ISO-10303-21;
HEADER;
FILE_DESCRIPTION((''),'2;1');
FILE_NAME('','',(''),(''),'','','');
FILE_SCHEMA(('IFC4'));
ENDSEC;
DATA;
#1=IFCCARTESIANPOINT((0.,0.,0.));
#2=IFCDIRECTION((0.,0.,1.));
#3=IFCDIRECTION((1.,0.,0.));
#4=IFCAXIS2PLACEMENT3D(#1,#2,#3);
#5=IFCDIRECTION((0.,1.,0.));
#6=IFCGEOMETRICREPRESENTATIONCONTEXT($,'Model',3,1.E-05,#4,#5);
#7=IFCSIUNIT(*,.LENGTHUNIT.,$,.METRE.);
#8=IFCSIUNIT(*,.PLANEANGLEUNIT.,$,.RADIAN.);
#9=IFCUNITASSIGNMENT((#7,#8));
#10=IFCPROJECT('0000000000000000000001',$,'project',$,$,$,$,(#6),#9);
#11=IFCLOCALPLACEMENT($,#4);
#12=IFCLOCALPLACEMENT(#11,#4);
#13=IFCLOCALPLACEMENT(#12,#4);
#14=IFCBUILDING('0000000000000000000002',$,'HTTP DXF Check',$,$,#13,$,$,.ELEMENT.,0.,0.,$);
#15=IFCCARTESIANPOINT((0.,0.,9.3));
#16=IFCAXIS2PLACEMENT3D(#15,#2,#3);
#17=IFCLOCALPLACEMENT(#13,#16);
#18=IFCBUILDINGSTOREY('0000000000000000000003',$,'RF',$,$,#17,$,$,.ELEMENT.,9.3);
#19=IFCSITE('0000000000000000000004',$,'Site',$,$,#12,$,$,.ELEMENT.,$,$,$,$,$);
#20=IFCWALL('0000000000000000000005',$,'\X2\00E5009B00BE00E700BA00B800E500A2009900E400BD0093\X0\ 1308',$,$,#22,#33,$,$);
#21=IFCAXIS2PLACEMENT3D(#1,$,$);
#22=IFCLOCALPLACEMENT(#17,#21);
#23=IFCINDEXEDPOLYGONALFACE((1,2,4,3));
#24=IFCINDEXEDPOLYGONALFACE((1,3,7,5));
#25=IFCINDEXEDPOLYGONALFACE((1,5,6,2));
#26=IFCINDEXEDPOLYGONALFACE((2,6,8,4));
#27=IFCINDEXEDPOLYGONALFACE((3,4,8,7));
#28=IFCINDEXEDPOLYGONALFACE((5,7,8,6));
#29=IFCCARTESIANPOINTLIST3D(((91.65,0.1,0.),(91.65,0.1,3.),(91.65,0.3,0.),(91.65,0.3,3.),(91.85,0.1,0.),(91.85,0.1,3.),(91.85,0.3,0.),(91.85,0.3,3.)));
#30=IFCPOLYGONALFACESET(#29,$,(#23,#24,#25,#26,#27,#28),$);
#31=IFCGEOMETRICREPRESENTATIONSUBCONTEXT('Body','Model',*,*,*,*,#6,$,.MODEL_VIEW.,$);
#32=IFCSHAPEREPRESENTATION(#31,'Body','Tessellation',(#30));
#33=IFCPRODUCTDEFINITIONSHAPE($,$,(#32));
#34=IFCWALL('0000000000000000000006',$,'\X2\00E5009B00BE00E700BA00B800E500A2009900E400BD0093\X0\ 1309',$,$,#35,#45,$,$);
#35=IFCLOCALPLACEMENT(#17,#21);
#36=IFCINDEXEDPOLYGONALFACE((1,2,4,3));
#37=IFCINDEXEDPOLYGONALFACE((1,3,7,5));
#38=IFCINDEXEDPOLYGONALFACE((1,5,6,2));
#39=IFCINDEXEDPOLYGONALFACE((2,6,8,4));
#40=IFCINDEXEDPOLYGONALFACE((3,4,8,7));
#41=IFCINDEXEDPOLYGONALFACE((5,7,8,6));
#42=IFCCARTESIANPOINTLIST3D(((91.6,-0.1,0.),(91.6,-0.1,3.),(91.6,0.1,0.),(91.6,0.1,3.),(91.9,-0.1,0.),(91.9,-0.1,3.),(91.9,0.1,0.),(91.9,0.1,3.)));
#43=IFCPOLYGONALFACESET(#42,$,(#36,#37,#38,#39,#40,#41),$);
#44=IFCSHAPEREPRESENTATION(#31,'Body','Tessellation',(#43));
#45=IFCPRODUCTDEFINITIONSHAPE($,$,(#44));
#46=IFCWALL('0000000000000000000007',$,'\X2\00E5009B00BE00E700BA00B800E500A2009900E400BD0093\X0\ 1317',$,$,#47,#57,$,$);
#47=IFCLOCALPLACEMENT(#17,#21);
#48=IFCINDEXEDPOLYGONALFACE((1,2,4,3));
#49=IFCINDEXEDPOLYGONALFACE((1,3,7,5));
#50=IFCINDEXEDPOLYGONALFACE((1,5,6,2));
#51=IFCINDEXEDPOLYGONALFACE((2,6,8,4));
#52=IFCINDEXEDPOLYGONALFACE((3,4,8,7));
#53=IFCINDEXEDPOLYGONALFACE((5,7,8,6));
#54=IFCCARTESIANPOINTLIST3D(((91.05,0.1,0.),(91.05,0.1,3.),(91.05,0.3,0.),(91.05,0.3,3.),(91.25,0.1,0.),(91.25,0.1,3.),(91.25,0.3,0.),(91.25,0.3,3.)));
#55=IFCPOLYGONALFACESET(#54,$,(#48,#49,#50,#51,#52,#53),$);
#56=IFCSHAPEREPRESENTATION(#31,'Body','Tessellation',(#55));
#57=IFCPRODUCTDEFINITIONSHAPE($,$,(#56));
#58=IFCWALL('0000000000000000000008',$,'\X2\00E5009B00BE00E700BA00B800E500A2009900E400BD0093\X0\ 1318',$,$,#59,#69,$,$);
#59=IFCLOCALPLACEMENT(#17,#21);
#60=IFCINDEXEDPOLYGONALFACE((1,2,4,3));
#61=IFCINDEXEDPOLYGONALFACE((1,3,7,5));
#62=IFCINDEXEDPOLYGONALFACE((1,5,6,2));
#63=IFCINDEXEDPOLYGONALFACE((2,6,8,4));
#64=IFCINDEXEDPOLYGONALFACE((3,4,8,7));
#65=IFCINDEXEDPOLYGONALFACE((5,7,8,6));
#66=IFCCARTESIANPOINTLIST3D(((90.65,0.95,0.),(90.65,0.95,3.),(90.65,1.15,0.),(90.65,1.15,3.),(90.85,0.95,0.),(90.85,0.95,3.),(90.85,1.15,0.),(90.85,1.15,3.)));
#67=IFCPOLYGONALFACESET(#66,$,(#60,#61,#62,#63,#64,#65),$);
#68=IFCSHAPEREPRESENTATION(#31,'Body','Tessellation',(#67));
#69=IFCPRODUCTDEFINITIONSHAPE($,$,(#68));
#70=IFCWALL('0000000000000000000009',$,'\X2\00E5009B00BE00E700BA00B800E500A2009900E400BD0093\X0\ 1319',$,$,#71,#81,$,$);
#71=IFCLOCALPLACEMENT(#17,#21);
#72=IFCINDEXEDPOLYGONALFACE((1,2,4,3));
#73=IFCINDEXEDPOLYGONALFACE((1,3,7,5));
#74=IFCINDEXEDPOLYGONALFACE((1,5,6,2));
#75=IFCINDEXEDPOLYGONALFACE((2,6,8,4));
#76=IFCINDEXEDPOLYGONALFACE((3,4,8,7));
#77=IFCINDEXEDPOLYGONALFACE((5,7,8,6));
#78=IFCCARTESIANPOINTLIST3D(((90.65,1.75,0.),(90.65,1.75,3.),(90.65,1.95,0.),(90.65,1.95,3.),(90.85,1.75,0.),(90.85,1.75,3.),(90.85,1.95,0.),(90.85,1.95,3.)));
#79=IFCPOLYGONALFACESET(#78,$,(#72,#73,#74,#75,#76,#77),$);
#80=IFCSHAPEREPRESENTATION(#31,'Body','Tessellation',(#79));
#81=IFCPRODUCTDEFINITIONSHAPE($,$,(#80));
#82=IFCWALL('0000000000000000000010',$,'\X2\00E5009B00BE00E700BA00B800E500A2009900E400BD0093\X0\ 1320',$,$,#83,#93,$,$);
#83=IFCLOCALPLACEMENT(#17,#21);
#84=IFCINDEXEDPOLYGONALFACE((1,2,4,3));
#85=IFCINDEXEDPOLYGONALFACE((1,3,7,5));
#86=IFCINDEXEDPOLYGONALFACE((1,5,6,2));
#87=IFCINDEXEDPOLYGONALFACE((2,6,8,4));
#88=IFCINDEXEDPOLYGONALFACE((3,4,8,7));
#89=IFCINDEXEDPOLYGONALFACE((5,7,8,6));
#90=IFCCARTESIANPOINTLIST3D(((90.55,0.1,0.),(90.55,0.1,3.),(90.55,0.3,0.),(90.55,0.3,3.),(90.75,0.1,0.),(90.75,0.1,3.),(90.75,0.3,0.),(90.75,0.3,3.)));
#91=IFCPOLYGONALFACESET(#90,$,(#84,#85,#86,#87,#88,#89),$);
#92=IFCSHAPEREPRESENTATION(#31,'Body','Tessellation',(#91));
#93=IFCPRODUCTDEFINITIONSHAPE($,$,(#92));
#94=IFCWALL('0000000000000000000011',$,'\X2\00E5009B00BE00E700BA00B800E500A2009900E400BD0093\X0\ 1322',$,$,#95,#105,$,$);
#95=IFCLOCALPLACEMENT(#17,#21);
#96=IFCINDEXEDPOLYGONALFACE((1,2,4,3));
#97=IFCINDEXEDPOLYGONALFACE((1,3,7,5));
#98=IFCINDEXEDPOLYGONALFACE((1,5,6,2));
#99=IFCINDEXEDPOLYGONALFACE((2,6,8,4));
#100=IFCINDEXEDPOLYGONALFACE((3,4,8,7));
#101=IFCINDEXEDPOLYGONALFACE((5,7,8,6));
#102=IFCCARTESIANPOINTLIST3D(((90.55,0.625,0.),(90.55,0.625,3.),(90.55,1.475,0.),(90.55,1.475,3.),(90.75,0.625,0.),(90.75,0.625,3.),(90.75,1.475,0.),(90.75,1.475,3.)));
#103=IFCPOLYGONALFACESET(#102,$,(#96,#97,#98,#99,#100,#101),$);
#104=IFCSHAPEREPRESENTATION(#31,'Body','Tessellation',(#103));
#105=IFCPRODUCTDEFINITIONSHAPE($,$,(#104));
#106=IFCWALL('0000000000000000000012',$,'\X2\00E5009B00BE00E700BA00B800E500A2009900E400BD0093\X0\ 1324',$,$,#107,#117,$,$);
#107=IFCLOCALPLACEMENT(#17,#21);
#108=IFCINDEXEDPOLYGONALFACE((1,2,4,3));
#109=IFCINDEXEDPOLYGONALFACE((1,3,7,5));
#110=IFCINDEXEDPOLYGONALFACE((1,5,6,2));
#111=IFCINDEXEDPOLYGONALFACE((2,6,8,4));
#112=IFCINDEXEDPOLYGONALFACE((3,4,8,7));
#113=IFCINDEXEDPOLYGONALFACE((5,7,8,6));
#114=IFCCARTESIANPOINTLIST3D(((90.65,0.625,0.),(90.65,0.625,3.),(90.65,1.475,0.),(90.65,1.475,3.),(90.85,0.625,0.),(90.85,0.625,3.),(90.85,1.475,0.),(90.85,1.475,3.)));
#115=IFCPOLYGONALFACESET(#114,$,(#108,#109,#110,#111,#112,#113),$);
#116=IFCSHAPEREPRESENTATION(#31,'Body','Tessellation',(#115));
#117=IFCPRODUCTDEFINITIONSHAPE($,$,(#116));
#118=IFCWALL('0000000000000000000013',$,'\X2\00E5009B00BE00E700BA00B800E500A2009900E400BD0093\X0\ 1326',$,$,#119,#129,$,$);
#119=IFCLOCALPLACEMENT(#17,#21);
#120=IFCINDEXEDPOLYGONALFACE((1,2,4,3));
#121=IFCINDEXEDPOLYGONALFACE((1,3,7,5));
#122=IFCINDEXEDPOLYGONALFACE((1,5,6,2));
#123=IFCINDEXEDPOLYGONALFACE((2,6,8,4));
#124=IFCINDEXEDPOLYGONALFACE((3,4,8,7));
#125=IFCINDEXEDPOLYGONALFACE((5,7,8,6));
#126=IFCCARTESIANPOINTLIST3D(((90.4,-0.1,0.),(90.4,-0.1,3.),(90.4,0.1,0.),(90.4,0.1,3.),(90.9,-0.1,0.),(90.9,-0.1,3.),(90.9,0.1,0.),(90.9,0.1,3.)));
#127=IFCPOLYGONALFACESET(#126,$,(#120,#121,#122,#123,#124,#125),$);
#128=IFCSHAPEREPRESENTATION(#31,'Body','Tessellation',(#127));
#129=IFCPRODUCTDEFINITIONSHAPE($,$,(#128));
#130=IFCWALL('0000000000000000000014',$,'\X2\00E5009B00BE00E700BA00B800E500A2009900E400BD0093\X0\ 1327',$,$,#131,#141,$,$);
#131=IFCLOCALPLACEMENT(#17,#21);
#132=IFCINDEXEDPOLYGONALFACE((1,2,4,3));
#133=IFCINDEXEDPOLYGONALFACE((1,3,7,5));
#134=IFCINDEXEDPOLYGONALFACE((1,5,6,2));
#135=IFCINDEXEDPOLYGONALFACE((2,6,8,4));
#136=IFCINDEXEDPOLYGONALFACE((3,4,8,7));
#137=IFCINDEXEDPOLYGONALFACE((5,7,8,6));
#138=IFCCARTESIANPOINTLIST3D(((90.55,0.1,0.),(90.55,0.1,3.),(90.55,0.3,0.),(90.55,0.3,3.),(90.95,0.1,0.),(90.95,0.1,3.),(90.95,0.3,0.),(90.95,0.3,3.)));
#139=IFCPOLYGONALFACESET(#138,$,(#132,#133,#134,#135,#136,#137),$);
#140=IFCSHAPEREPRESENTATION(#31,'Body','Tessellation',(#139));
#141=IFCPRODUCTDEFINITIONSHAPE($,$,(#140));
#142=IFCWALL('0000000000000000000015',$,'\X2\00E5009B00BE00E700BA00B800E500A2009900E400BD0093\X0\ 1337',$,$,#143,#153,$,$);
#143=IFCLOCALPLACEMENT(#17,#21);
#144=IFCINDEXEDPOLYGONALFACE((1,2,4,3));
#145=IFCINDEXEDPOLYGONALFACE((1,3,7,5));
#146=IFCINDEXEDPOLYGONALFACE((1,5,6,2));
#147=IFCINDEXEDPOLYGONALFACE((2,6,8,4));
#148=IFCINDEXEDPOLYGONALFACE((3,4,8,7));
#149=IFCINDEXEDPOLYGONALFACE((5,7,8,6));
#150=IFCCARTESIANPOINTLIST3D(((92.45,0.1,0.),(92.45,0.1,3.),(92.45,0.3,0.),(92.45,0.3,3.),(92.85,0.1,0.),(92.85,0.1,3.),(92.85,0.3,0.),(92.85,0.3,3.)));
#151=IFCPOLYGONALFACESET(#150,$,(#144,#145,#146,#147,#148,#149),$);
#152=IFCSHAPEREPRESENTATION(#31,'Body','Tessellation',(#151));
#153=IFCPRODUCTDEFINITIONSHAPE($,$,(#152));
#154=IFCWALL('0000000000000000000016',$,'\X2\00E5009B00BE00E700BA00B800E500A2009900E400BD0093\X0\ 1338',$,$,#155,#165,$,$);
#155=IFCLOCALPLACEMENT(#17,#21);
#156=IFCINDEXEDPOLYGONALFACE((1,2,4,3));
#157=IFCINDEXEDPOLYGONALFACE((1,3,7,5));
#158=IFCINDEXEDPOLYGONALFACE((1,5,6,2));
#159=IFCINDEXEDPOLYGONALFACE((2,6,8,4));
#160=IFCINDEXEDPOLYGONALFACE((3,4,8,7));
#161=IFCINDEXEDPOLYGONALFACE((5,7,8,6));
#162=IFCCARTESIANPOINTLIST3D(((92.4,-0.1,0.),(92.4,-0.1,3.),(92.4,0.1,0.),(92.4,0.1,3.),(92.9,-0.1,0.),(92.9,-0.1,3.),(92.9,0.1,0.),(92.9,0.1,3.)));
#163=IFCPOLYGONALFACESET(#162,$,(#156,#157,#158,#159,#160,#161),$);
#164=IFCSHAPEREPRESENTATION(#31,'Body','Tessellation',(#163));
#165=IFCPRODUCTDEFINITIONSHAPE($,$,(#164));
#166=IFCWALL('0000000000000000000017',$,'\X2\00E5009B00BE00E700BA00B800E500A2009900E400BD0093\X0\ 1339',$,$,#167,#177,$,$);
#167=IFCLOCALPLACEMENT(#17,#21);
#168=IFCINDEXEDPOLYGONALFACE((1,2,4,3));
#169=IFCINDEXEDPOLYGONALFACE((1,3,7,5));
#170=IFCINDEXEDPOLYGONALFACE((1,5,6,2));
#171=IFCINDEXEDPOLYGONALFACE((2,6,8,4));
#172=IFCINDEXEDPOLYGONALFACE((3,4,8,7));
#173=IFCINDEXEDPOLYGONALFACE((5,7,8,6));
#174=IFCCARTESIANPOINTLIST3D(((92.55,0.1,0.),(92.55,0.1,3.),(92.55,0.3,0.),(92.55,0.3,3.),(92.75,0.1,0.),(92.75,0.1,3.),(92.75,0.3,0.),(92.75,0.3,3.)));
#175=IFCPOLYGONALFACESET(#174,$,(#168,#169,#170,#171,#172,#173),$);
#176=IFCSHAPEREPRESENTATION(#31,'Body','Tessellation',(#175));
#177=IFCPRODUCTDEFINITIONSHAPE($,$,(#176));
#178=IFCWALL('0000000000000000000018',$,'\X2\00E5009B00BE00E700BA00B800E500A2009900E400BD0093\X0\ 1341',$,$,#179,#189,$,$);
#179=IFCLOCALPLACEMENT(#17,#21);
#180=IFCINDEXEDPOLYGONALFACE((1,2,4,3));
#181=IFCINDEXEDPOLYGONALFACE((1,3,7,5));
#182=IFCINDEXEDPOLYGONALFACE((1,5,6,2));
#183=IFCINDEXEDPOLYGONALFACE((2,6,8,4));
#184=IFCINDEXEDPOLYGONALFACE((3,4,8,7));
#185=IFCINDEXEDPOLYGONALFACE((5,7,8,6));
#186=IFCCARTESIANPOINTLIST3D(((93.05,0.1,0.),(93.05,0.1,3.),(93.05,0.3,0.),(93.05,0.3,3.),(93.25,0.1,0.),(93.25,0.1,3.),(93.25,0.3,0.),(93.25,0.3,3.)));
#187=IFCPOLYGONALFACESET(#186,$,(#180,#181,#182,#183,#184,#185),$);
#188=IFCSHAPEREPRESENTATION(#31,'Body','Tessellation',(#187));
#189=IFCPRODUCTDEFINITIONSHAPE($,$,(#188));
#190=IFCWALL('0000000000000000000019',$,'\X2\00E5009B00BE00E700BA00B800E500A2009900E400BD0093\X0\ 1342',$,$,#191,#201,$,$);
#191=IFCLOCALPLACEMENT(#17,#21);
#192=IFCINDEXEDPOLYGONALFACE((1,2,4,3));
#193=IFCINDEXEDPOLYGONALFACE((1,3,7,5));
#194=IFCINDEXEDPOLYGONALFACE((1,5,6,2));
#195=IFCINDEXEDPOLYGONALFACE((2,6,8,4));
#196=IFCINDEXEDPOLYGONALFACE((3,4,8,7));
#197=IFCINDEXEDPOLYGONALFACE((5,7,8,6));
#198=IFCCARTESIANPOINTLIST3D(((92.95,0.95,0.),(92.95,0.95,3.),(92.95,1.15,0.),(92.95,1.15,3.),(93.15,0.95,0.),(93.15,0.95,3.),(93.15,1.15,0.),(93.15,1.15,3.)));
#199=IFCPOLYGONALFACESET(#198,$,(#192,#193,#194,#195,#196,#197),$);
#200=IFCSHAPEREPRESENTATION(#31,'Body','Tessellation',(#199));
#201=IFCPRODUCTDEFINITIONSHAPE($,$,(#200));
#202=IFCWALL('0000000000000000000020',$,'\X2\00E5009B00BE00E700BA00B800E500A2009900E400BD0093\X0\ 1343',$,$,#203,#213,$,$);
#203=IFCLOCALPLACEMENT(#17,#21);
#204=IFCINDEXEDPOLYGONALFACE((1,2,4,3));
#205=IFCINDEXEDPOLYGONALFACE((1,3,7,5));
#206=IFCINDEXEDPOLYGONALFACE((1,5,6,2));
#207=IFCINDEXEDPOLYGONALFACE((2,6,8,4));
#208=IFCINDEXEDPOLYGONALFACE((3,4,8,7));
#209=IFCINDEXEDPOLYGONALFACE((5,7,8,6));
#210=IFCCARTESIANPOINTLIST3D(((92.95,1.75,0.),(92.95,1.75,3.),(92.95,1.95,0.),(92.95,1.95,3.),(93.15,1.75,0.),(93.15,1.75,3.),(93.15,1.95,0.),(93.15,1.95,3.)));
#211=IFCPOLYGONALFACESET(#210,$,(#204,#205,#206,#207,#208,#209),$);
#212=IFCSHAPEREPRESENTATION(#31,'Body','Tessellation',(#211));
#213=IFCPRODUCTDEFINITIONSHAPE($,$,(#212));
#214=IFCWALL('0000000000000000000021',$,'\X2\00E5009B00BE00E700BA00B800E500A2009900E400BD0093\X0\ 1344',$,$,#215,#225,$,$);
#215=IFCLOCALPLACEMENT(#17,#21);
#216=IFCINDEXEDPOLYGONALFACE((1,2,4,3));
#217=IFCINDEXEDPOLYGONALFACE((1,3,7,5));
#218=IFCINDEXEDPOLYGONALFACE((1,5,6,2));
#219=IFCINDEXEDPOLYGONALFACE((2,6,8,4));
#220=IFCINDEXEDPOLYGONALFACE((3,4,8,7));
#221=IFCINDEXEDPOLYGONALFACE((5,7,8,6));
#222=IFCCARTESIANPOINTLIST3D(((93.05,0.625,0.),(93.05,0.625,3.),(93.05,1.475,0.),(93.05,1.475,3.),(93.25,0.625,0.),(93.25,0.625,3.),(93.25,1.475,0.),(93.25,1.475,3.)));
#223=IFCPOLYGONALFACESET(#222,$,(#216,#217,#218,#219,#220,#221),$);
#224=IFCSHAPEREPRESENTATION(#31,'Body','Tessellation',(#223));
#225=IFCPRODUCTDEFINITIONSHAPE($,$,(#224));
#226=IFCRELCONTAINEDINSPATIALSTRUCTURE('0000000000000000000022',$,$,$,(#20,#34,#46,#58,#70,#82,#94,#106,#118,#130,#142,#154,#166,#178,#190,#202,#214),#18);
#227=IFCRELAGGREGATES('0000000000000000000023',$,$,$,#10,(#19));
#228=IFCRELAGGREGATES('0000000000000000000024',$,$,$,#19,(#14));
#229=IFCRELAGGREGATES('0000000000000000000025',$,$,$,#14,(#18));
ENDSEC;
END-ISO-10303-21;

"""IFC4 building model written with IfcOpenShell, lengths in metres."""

from ifc_helpers import new_model, si_unit, direction, frame, frame_2d, origin_with_axes, place, context, subcontext, project, spatial, rectangle, extrude, element, save


model = new_model("IFC4")

# Units and contexts
model_context = context("Model", 3, precision=1e-05, world=origin_with_axes(), true_north=direction((0.0, 1.0, 0.0)))
body_context = subcontext(model_context, "Body", "Model", "MODEL_VIEW")
ifc_project = project(units=[si_unit("LENGTHUNIT", "METRE"), si_unit("PLANEANGLEUNIT", "RADIAN")], contexts=[model_context])

# Site, building, storey
placement = place(None, origin_with_axes())
site_placement = place(placement, origin_with_axes())
site = spatial("IfcSite", under=ifc_project, at=site_placement, Name="Site", CompositionType="ELEMENT")
building_placement = place(site_placement, origin_with_axes())
building = spatial("IfcBuilding", under=site, at=building_placement, Name="HTTP DXF Check", CompositionType="ELEMENT", ElevationOfRefHeight=0.0, ElevationOfTerrain=0.0)
storey_placement = place(building_placement, frame((0.0, 0.0, 9.3), z_axis=(0.0, 0.0, 1.0), x_axis=(1.0, 0.0, 0.0)))
storey = spatial("IfcBuildingStorey", under=building, at=storey_placement, Name="RF", CompositionType="ELEMENT", Elevation=9.3)

# Walls
wall_1_placement = place(storey_placement, frame((91.75, 0.2, 0.0), z_axis=(0.0, 0.0, 1.0), x_axis=(1.0, 0.0, 0.0)))
element("IfcWall", 1, at=wall_1_placement, inside=storey, Name="å\u009b¾çº¸å¢\u0099ä½\u0093 1308", context=body_context, shape_type="SweptSolid", body=[
    extrude(rectangle(XDim=0.2, YDim=0.2, at=frame_2d((0.0, 0.0), x_axis=(1.0, 0.0, 0.0))), frame((0.0, 0.0, 0.0), z_axis=(0.0, 0.0, 1.0)), (0.0, 0.0, 1.0), 3.0),
])
wall_2_placement = place(storey_placement, frame((91.75, 0.0, 0.0), z_axis=(0.0, 0.0, 1.0), x_axis=(1.0, 0.0, 0.0)))
element("IfcWall", 2, at=wall_2_placement, inside=storey, Name="å\u009b¾çº¸å¢\u0099ä½\u0093 1309", context=body_context, shape_type="SweptSolid", body=[
    extrude(rectangle(XDim=0.3, YDim=0.2, at=frame_2d((0.0, 0.0), x_axis=(1.0, 0.0, 0.0))), frame((0.0, 0.0, 0.0), z_axis=(0.0, 0.0, 1.0)), (0.0, 0.0, 1.0), 3.0),
])
for number, where, z_axis, x_axis, name in (
    (3, (91.15, 0.2, 0.0), (0.0, 0.0, 1.0), (0.0, -1.0, 0.0), "å\u009b¾çº¸å¢\u0099ä½\u0093 1317"),
    (4, (90.75, 1.05, 0.0), (0.0, 0.0, 1.0), (-1.0, 0.0, 0.0), "å\u009b¾çº¸å¢\u0099ä½\u0093 1318"),
    (5, (90.75, 1.85, 0.0), (0.0, 0.0, 1.0), (-1.0, 0.0, 0.0), "å\u009b¾çº¸å¢\u0099ä½\u0093 1319"),
    (6, (90.65, 0.2, 0.0), (0.0, 0.0, 1.0), (0.0, -1.0, 0.0), "å\u009b¾çº¸å¢\u0099ä½\u0093 1320"),
):
    element("IfcWall", number, at=place(storey_placement, frame(where, z_axis=z_axis, x_axis=x_axis)), inside=storey, Name=name, context=body_context, shape_type="SweptSolid", body=[
        extrude(rectangle(XDim=0.2, YDim=0.2, at=frame_2d((0.0, 0.0), x_axis=(1.0, 0.0, 0.0))), frame((0.0, 0.0, 0.0), z_axis=(0.0, 0.0, 1.0)), (0.0, 0.0, 1.0), 3.0),
    ])
for number, where, z_axis, x_axis, name in (
    (7, (90.65, 1.05, 0.0), (0.0, 0.0, 1.0), (0.0, -1.0, 0.0), "å\u009b¾çº¸å¢\u0099ä½\u0093 1322"),
    (8, (90.75, 1.05, 0.0), (0.0, 0.0, 1.0), (0.0, -1.0, 0.0), "å\u009b¾çº¸å¢\u0099ä½\u0093 1324"),
):
    element("IfcWall", number, at=place(storey_placement, frame(where, z_axis=z_axis, x_axis=x_axis)), inside=storey, Name=name, context=body_context, shape_type="SweptSolid", body=[
        extrude(rectangle(XDim=0.85, YDim=0.2, at=frame_2d((0.0, 0.0), x_axis=(1.0, 0.0, 0.0))), frame((0.0, 0.0, 0.0), z_axis=(0.0, 0.0, 1.0)), (0.0, 0.0, 1.0), 3.0),
    ])
wall_3_placement = place(storey_placement, frame((90.65, 0.0, 0.0), z_axis=(0.0, 0.0, 1.0), x_axis=(1.0, 0.0, 0.0)))
element("IfcWall", 9, at=wall_3_placement, inside=storey, Name="å\u009b¾çº¸å¢\u0099ä½\u0093 1326", context=body_context, shape_type="SweptSolid", body=[
    extrude(rectangle(XDim=0.5, YDim=0.2, at=frame_2d((0.0, 0.0), x_axis=(1.0, 0.0, 0.0))), frame((0.0, 0.0, 0.0), z_axis=(0.0, 0.0, 1.0)), (0.0, 0.0, 1.0), 3.0),
])
for number, where, z_axis, x_axis, name in (
    (10, (90.75, 0.2, 0.0), (0.0, 0.0, 1.0), (1.0, 0.0, 0.0), "å\u009b¾çº¸å¢\u0099ä½\u0093 1327"),
    (11, (92.65, 0.2, 0.0), (0.0, 0.0, 1.0), (1.0, 0.0, 0.0), "å\u009b¾çº¸å¢\u0099ä½\u0093 1337"),
):
    element("IfcWall", number, at=place(storey_placement, frame(where, z_axis=z_axis, x_axis=x_axis)), inside=storey, Name=name, context=body_context, shape_type="SweptSolid", body=[
        extrude(rectangle(XDim=0.4, YDim=0.2, at=frame_2d((0.0, 0.0), x_axis=(1.0, 0.0, 0.0))), frame((0.0, 0.0, 0.0), z_axis=(0.0, 0.0, 1.0)), (0.0, 0.0, 1.0), 3.0),
    ])
wall_4_placement = place(storey_placement, frame((92.65, 0.0, 0.0), z_axis=(0.0, 0.0, 1.0), x_axis=(1.0, 0.0, 0.0)))
element("IfcWall", 12, at=wall_4_placement, inside=storey, Name="å\u009b¾çº¸å¢\u0099ä½\u0093 1338", context=body_context, shape_type="SweptSolid", body=[
    extrude(rectangle(XDim=0.5, YDim=0.2, at=frame_2d((0.0, 0.0), x_axis=(1.0, 0.0, 0.0))), frame((0.0, 0.0, 0.0), z_axis=(0.0, 0.0, 1.0)), (0.0, 0.0, 1.0), 3.0),
])
for number, where, z_axis, x_axis, name in (
    (13, (92.65, 0.2, 0.0), (0.0, 0.0, 1.0), (0.0, -1.0, 0.0), "å\u009b¾çº¸å¢\u0099ä½\u0093 1339"),
    (14, (93.15, 0.2, 0.0), (0.0, 0.0, 1.0), (0.0, -1.0, 0.0), "å\u009b¾çº¸å¢\u0099ä½\u0093 1341"),
    (15, (93.05, 1.05, 0.0), (0.0, 0.0, 1.0), (1.0, 0.0, 0.0), "å\u009b¾çº¸å¢\u0099ä½\u0093 1342"),
    (16, (93.05, 1.85, 0.0), (0.0, 0.0, 1.0), (1.0, 0.0, 0.0), "å\u009b¾çº¸å¢\u0099ä½\u0093 1343"),
):
    element("IfcWall", number, at=place(storey_placement, frame(where, z_axis=z_axis, x_axis=x_axis)), inside=storey, Name=name, context=body_context, shape_type="SweptSolid", body=[
        extrude(rectangle(XDim=0.2, YDim=0.2, at=frame_2d((0.0, 0.0), x_axis=(1.0, 0.0, 0.0))), frame((0.0, 0.0, 0.0), z_axis=(0.0, 0.0, 1.0)), (0.0, 0.0, 1.0), 3.0),
    ])
for number, where, z_axis, x_axis, name in (
    (17, (93.15, 1.05, 0.0), (0.0, 0.0, 1.0), (0.0, -1.0, 0.0), "å\u009b¾çº¸å¢\u0099ä½\u0093 1344"),
):
    element("IfcWall", number, at=place(storey_placement, frame(where, z_axis=z_axis, x_axis=x_axis)), inside=storey, Name=name, context=body_context, shape_type="SweptSolid", body=[
        extrude(rectangle(XDim=0.85, YDim=0.2, at=frame_2d((0.0, 0.0), x_axis=(1.0, 0.0, 0.0))), frame((0.0, 0.0, 0.0), z_axis=(0.0, 0.0, 1.0)), (0.0, 0.0, 1.0), 3.0),
    ])

save(model, "model.ifc")
